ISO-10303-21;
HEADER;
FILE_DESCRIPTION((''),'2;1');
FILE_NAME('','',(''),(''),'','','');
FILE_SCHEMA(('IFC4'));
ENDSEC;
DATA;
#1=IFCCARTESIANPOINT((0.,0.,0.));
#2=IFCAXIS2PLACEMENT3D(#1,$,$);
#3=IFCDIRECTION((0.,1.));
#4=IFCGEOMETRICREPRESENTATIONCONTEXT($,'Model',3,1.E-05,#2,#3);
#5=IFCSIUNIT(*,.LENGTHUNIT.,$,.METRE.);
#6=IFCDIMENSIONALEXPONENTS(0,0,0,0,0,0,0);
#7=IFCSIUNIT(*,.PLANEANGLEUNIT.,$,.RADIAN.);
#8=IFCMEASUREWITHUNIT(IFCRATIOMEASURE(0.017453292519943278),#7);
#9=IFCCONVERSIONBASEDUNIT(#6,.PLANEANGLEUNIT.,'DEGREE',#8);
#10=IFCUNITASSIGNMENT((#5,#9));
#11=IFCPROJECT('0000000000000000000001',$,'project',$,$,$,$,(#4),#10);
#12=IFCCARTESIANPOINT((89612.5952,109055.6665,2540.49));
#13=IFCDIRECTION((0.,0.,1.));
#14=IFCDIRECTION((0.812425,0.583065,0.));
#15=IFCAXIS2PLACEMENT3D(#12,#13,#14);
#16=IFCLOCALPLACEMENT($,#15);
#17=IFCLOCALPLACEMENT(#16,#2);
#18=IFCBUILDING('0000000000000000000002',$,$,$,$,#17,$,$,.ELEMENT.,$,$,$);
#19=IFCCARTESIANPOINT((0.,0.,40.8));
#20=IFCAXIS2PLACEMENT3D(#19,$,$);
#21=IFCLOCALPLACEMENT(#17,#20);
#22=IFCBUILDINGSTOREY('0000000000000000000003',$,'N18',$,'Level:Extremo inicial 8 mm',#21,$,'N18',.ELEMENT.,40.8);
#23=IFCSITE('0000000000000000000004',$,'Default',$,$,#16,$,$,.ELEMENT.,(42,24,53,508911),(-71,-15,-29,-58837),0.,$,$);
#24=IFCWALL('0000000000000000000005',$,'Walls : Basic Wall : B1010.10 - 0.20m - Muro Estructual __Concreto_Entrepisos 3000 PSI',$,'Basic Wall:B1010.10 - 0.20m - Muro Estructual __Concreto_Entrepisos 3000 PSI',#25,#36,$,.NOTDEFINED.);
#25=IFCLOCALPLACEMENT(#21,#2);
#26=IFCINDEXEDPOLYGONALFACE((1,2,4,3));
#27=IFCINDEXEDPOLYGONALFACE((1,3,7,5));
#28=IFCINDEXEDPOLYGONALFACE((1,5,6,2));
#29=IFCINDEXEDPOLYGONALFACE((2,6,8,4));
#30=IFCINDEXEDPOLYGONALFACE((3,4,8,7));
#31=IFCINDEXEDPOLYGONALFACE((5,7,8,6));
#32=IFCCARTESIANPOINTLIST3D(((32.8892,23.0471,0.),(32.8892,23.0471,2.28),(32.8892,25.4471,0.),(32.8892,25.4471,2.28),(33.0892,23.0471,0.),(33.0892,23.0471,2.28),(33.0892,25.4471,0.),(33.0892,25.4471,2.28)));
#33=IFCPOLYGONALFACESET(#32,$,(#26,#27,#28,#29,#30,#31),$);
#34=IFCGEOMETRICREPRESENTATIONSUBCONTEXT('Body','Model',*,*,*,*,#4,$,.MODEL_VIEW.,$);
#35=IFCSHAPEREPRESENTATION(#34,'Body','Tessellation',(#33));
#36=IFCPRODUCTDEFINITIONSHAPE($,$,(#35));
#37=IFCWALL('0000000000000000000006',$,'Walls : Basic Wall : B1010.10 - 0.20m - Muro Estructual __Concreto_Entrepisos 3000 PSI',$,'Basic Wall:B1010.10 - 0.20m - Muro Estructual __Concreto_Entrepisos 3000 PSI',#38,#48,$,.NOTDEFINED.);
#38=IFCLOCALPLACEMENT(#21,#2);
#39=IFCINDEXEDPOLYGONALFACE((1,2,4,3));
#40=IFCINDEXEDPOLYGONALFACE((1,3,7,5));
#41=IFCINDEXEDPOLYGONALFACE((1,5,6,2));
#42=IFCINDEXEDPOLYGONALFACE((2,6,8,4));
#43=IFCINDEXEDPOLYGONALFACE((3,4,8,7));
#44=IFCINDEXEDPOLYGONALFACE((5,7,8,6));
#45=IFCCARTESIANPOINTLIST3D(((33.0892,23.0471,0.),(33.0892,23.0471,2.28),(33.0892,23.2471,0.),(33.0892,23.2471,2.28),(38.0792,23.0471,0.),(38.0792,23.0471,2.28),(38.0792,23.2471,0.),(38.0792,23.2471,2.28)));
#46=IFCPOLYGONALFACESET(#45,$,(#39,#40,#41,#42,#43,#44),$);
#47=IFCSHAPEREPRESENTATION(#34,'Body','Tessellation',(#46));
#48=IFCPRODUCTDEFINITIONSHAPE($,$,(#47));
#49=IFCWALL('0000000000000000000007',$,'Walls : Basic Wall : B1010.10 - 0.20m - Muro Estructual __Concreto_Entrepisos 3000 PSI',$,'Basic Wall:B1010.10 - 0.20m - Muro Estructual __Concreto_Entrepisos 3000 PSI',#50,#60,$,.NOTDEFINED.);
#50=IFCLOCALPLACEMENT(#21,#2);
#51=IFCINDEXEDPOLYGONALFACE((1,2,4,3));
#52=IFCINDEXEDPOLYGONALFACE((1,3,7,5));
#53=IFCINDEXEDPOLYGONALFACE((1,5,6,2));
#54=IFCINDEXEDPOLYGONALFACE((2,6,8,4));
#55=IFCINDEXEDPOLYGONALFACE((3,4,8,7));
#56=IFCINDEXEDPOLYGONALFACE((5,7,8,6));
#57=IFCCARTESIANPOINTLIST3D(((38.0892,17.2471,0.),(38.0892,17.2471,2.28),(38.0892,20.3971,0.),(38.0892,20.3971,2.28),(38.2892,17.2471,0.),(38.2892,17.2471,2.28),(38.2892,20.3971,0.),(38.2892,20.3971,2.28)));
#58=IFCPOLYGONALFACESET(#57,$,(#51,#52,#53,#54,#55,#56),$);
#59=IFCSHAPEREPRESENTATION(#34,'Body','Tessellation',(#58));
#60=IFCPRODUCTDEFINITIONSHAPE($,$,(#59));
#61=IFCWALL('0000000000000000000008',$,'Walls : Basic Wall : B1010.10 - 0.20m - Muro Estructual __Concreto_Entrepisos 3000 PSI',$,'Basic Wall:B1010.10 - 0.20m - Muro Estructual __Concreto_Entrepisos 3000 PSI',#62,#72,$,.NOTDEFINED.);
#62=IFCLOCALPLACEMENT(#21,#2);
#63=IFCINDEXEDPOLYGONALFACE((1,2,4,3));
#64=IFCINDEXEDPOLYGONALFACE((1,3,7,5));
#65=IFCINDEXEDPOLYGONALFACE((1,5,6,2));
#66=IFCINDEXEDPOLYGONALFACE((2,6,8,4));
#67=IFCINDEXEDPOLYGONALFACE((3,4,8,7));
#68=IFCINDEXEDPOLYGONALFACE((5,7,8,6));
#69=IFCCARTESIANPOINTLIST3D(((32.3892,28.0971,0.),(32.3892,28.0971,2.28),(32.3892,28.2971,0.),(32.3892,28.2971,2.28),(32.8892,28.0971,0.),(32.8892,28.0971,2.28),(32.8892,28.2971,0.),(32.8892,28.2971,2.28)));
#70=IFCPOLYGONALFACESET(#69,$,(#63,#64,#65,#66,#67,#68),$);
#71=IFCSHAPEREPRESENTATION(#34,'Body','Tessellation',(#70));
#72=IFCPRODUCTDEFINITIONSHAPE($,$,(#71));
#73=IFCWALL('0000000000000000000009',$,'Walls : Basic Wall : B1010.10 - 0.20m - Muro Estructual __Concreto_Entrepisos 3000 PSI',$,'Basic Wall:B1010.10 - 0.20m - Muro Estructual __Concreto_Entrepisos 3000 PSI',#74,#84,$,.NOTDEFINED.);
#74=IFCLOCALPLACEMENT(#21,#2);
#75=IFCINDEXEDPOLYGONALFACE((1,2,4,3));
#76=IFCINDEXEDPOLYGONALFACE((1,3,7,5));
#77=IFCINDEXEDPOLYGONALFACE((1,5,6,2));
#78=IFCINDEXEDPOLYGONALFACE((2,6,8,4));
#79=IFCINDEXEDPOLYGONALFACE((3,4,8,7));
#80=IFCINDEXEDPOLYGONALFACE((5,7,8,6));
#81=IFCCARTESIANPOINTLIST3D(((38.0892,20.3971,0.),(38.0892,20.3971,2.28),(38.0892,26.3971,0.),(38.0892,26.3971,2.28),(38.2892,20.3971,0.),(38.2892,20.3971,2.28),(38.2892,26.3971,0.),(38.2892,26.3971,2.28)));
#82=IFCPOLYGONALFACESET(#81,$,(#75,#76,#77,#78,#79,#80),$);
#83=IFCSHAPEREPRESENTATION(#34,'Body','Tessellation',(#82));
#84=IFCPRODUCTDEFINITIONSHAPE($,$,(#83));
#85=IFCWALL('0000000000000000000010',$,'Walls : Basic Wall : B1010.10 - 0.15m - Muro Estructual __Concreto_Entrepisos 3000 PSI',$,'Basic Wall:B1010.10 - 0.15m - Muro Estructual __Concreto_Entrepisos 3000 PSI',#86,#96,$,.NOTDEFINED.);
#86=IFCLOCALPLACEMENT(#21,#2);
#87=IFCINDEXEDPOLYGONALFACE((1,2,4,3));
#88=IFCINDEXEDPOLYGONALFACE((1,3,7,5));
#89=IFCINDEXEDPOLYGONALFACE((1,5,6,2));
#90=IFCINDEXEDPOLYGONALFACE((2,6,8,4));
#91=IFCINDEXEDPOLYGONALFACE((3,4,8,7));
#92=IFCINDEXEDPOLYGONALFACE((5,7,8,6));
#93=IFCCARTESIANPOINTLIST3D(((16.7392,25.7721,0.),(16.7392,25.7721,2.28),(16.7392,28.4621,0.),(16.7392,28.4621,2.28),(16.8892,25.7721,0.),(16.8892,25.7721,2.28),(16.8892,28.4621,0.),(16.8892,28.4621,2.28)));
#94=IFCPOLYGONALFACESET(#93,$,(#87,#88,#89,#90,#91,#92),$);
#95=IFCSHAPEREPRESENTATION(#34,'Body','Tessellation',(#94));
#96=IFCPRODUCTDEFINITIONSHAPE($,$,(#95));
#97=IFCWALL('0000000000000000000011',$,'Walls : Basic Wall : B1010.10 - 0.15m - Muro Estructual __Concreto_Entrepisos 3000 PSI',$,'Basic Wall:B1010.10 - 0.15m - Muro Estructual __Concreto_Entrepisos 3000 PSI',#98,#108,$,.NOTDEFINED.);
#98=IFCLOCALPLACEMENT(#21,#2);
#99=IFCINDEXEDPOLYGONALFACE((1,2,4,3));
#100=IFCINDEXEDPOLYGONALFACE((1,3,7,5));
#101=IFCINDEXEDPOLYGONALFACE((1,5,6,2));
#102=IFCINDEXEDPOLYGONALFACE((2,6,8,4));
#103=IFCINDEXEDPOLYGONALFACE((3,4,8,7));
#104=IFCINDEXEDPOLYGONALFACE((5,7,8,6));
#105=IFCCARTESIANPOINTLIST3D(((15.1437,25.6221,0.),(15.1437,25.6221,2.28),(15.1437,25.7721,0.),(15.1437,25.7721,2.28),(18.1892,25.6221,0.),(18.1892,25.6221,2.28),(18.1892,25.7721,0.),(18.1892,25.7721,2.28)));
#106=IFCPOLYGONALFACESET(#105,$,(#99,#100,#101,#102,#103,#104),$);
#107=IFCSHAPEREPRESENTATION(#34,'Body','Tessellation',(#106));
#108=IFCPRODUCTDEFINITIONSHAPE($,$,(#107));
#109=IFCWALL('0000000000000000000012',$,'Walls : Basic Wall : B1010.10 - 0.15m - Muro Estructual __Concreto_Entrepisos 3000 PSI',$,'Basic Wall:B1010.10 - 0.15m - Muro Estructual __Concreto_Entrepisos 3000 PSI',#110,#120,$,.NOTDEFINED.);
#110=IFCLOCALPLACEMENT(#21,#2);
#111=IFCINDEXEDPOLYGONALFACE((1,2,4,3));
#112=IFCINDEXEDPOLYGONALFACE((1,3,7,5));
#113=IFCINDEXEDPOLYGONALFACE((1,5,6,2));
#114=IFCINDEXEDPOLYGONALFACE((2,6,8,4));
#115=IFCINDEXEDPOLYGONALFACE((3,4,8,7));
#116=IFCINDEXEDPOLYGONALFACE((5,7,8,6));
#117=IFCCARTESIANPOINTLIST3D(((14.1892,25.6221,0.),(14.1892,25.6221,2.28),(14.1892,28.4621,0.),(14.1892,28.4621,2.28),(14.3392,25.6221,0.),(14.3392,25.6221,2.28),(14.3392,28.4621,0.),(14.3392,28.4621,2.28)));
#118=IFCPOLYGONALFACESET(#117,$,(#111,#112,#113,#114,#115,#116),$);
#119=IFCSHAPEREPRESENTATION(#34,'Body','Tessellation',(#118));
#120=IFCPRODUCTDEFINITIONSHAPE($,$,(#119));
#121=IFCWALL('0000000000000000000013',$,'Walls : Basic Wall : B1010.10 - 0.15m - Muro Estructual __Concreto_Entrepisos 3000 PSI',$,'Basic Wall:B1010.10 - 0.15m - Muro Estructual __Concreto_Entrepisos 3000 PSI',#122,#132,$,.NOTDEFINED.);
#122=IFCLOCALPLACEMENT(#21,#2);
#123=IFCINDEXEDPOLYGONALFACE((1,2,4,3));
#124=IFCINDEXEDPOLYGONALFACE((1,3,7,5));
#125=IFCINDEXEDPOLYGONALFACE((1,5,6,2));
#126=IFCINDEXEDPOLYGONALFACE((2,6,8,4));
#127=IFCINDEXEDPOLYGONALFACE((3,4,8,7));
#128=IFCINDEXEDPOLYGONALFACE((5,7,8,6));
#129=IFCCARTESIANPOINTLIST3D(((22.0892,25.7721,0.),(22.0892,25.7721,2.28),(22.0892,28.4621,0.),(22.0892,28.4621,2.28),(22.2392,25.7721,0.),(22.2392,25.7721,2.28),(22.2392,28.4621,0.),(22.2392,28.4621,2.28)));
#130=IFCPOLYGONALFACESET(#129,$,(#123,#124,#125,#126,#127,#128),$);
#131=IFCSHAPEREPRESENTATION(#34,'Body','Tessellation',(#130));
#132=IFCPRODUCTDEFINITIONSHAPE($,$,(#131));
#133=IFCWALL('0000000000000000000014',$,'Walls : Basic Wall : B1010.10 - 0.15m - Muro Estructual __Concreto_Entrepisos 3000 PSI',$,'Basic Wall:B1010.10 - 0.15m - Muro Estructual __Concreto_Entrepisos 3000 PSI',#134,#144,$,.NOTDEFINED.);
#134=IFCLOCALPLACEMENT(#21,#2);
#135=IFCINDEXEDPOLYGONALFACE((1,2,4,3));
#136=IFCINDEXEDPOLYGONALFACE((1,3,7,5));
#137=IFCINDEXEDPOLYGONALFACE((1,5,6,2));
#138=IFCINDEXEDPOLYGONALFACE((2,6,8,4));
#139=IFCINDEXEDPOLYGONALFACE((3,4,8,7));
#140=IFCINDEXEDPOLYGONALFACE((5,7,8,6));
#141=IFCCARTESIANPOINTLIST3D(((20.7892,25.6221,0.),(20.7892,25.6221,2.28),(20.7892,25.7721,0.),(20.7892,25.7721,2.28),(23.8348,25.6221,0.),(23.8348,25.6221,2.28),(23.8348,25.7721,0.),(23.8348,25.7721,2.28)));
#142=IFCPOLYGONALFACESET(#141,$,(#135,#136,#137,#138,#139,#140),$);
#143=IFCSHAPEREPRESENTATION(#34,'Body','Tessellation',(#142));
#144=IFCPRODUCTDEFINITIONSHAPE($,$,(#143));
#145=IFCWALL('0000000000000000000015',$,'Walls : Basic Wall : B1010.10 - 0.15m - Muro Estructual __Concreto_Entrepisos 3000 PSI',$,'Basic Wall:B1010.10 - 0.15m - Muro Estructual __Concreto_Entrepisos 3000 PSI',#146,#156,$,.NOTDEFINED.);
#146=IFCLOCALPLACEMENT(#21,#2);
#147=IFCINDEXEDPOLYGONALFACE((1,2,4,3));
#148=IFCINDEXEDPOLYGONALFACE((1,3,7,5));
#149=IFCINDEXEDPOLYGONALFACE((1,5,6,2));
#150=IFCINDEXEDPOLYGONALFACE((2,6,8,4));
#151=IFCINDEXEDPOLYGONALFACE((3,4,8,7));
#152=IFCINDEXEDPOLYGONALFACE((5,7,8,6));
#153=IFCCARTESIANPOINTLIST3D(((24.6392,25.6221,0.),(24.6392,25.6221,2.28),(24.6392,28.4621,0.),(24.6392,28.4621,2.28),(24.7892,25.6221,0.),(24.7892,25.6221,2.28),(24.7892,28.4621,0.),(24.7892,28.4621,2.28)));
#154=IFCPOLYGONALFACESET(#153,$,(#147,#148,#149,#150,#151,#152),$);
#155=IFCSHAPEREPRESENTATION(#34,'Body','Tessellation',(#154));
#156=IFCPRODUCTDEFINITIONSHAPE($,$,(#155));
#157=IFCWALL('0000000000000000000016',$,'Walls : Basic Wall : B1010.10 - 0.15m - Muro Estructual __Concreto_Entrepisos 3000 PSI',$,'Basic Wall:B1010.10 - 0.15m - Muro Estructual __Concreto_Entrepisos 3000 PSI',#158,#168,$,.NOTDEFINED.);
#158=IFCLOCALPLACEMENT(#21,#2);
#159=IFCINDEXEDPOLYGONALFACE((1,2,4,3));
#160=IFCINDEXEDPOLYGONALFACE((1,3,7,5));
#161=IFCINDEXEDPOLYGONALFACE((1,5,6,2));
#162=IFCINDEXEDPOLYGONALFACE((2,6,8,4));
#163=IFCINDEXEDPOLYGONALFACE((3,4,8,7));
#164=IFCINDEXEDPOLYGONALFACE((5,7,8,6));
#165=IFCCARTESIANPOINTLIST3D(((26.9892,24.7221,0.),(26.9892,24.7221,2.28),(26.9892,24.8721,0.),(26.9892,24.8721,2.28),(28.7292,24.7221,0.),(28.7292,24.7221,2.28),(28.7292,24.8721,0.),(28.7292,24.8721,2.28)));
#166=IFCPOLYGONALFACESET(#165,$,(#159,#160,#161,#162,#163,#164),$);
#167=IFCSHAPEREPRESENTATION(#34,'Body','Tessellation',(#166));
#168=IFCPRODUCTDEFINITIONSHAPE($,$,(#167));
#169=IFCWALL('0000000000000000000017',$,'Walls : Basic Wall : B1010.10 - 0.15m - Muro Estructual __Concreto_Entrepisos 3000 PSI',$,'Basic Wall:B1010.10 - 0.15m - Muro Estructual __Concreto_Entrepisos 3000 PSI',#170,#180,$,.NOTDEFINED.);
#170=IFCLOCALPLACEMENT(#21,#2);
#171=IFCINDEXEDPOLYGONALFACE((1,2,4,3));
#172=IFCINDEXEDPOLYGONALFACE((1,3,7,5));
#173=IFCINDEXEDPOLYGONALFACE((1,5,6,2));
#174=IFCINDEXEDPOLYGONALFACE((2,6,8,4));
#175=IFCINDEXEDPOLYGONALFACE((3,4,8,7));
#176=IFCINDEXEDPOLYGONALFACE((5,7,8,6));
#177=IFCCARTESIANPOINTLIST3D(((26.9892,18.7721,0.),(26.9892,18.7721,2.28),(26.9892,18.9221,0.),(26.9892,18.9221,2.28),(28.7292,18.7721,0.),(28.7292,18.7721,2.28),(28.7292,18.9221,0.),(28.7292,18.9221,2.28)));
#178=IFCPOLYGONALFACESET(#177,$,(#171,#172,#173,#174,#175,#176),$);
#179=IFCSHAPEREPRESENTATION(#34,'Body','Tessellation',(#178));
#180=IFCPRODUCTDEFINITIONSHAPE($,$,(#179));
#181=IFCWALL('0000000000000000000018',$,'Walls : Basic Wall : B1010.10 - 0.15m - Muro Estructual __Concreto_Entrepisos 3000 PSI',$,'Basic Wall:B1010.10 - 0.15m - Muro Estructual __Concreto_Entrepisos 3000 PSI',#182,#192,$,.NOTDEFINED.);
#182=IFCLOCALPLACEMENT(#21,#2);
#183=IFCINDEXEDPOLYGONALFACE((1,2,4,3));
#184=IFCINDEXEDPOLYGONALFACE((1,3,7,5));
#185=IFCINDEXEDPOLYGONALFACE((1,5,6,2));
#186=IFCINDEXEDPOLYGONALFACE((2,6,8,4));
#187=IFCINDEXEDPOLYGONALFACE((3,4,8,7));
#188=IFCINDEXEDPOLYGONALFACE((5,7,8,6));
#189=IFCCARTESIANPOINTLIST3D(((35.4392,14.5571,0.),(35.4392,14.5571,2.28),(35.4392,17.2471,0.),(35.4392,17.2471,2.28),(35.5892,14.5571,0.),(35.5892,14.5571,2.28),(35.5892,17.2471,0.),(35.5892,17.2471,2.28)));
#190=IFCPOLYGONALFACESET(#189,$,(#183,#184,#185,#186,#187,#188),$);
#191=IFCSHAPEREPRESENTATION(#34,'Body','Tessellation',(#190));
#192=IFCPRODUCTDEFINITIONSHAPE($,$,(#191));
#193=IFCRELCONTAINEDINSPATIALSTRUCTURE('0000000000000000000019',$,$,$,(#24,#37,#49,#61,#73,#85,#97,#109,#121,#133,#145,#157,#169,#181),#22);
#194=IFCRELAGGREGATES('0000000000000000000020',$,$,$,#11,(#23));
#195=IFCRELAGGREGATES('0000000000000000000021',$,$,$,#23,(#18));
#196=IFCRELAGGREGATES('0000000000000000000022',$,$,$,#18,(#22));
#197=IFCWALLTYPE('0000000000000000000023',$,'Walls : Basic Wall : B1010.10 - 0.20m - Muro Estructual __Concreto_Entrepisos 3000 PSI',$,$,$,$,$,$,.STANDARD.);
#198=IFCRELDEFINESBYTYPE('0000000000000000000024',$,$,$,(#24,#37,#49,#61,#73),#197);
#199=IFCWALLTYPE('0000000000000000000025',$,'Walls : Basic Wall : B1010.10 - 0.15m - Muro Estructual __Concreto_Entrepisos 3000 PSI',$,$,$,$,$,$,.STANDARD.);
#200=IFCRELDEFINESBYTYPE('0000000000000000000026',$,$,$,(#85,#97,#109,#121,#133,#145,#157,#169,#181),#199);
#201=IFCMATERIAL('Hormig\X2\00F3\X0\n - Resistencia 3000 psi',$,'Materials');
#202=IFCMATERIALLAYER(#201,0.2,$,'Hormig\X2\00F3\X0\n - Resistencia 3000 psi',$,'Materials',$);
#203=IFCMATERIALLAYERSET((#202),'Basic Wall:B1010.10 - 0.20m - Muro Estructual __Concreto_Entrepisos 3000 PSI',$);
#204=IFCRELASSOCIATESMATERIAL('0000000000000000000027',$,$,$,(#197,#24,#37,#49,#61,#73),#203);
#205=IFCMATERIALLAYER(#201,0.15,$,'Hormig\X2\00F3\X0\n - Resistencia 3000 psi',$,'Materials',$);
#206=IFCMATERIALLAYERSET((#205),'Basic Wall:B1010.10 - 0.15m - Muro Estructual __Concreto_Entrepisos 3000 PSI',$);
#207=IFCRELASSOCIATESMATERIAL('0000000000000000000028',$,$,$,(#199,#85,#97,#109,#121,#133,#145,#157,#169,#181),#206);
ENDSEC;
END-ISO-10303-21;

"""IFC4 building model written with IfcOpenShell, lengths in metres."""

from ifc_helpers import new_model, entity, si_unit, converted_unit, direction, frame, frame_2d, origin, place, context, subcontext, project, spatial, rectangle, extrude, material, layer, layer_set, layer_usage, type_object, element, save


model = new_model("IFC4")

# Units and contexts
model_context = context("Model", 3, precision=1e-05, world=origin(), true_north=direction((0.0, 1.0)))
body_context = subcontext(model_context, "Body", "Model", "MODEL_VIEW")
ifc_project = project(units=[si_unit("LENGTHUNIT", "METRE"), converted_unit("PLANEANGLEUNIT", "DEGREE", entity("IfcRatioMeasure", 0.017453292519943278), si_unit("PLANEANGLEUNIT", "RADIAN"), dimensions=[0, 0, 0, 0, 0, 0, 0])], contexts=[model_context])

# Site, building, storey
site_placement = place(None, frame((89612.5952, 109055.6665, 2540.49), z_axis=(0.0, 0.0, 1.0), x_axis=(0.812425, 0.583065, 0.0)))
site = spatial("IfcSite", under=ifc_project, at=site_placement, Name="Default", CompositionType="ELEMENT", RefLatitude=(42, 24, 53, 508911), RefLongitude=(-71, -15, -29, -58837), RefElevation=0.0)
building_placement = place(site_placement, origin())
building = spatial("IfcBuilding", under=site, at=building_placement, CompositionType="ELEMENT")
storey_placement = place(building_placement, frame((0.0, 0.0, 40.8)))
storey = spatial("IfcBuildingStorey", under=building, at=storey_placement, Name="N18", ObjectType="Level:Extremo inicial 8 mm", LongName="N18", CompositionType="ELEMENT", Elevation=40.8)

# Walls
ifc_material = material(Name="Hormigón - Resistencia 3000 psi", Category="Materials")
ifc_layer_1 = layer(ifc_material, 0.2, Name="Hormigón - Resistencia 3000 psi", Category="Materials")
ifc_layer_set_1 = layer_set([ifc_layer_1], Name="Basic Wall:B1010.10 - 0.20m - Muro Estructual __Concreto_Entrepisos 3000 PSI")
wall_type_1 = type_object("IfcWallType", Name="Walls : Basic Wall : B1010.10 - 0.20m - Muro Estructual __Concreto_Entrepisos 3000 PSI", PredefinedType="STANDARD", material=ifc_layer_set_1)
ifc_layer_usage_1 = layer_usage(ifc_layer_set_1, "AXIS2", "POSITIVE", -0.1)
wall_1_placement = place(storey_placement, frame((32.9892, 25.4471, 0.0), z_axis=(0.0, 0.0, 1.0), x_axis=(0.0, -1.0, 0.0)))
element("IfcWall", 1, at=wall_1_placement, inside=storey, type_object=wall_type_1, material=ifc_layer_usage_1, Name="Walls : Basic Wall : B1010.10 - 0.20m - Muro Estructual __Concreto_Entrepisos 3000 PSI", ObjectType="Basic Wall:B1010.10 - 0.20m - Muro Estructual __Concreto_Entrepisos 3000 PSI", PredefinedType="NOTDEFINED", context=body_context, shape_type="SweptSolid", body=[
    extrude(rectangle(XDim=2.4, YDim=0.2, at=frame_2d((1.2, 0.0), x_axis=(-1.0, 0.0))), origin(), (0.0, 0.0, 1.0), 2.28),
])
ifc_layer_usage_2 = layer_usage(ifc_layer_set_1, "AXIS2", "POSITIVE", -0.1)
wall_2_placement = place(storey_placement, frame((33.0892, 23.1471, 0.0)))
element("IfcWall", 2, at=wall_2_placement, inside=storey, type_object=wall_type_1, material=ifc_layer_usage_2, Name="Walls : Basic Wall : B1010.10 - 0.20m - Muro Estructual __Concreto_Entrepisos 3000 PSI", ObjectType="Basic Wall:B1010.10 - 0.20m - Muro Estructual __Concreto_Entrepisos 3000 PSI", PredefinedType="NOTDEFINED", context=body_context, shape_type="SweptSolid", body=[
    extrude(rectangle(XDim=4.99, YDim=0.2, at=frame_2d((2.495, 0.0), x_axis=(-1.0, 0.0))), origin(), (0.0, 0.0, 1.0), 2.28),
])
ifc_layer_usage_3 = layer_usage(ifc_layer_set_1, "AXIS2", "POSITIVE", -0.1)
wall_3_placement = place(storey_placement, frame((38.1892, 17.2471, 0.0), z_axis=(0.0, 0.0, 1.0), x_axis=(0.0, 1.0, 0.0)))
element("IfcWall", 3, at=wall_3_placement, inside=storey, type_object=wall_type_1, material=ifc_layer_usage_3, Name="Walls : Basic Wall : B1010.10 - 0.20m - Muro Estructual __Concreto_Entrepisos 3000 PSI", ObjectType="Basic Wall:B1010.10 - 0.20m - Muro Estructual __Concreto_Entrepisos 3000 PSI", PredefinedType="NOTDEFINED", context=body_context, shape_type="SweptSolid", body=[
    extrude(rectangle(XDim=3.15, YDim=0.2, at=frame_2d((1.575, 0.0), x_axis=(-1.0, 0.0))), origin(), (0.0, 0.0, 1.0), 2.28),
])
ifc_layer_usage_4 = layer_usage(ifc_layer_set_1, "AXIS2", "POSITIVE", -0.1)
wall_4_placement = place(storey_placement, frame((32.3892, 28.1971, 0.0)))
element("IfcWall", 4, at=wall_4_placement, inside=storey, type_object=wall_type_1, material=ifc_layer_usage_4, Name="Walls : Basic Wall : B1010.10 - 0.20m - Muro Estructual __Concreto_Entrepisos 3000 PSI", ObjectType="Basic Wall:B1010.10 - 0.20m - Muro Estructual __Concreto_Entrepisos 3000 PSI", PredefinedType="NOTDEFINED", context=body_context, shape_type="SweptSolid", body=[
    extrude(rectangle(XDim=0.5, YDim=0.2, at=frame_2d((0.25, 0.0), x_axis=(-1.0, 0.0))), origin(), (0.0, 0.0, 1.0), 2.28),
])
ifc_layer_usage_5 = layer_usage(ifc_layer_set_1, "AXIS2", "POSITIVE", -0.1)
wall_5_placement = place(storey_placement, frame((38.1892, 20.3971, 0.0), z_axis=(0.0, 0.0, 1.0), x_axis=(0.0, 1.0, 0.0)))
element("IfcWall", 5, at=wall_5_placement, inside=storey, type_object=wall_type_1, material=ifc_layer_usage_5, Name="Walls : Basic Wall : B1010.10 - 0.20m - Muro Estructual __Concreto_Entrepisos 3000 PSI", ObjectType="Basic Wall:B1010.10 - 0.20m - Muro Estructual __Concreto_Entrepisos 3000 PSI", PredefinedType="NOTDEFINED", context=body_context, shape_type="SweptSolid", body=[
    extrude(rectangle(XDim=6.0, YDim=0.2, at=frame_2d((3.0, 0.0), x_axis=(-1.0, 0.0))), origin(), (0.0, 0.0, 1.0), 2.28),
])
ifc_layer_2 = layer(ifc_material, 0.15, Name="Hormigón - Resistencia 3000 psi", Category="Materials")
ifc_layer_set_2 = layer_set([ifc_layer_2], Name="Basic Wall:B1010.10 - 0.15m - Muro Estructual __Concreto_Entrepisos 3000 PSI")
ifc_layer_usage_6 = layer_usage(ifc_layer_set_2, "AXIS2", "POSITIVE", -0.075)
wall_type_2 = type_object("IfcWallType", Name="Walls : Basic Wall : B1010.10 - 0.15m - Muro Estructual __Concreto_Entrepisos 3000 PSI", PredefinedType="STANDARD", material=ifc_layer_set_2)
wall_6_placement = place(storey_placement, frame((16.8142, 28.4621, 0.0), z_axis=(0.0, 0.0, 1.0), x_axis=(0.0, -1.0, 0.0)))
element("IfcWall", 6, at=wall_6_placement, inside=storey, type_object=wall_type_2, material=ifc_layer_usage_6, Name="Walls : Basic Wall : B1010.10 - 0.15m - Muro Estructual __Concreto_Entrepisos 3000 PSI", ObjectType="Basic Wall:B1010.10 - 0.15m - Muro Estructual __Concreto_Entrepisos 3000 PSI", PredefinedType="NOTDEFINED", context=body_context, shape_type="SweptSolid", body=[
    extrude(rectangle(XDim=2.69, YDim=0.15, at=frame_2d((1.345, 0.0), x_axis=(-1.0, 0.0))), origin(), (0.0, 0.0, 1.0), 2.28),
])
ifc_layer_usage_7 = layer_usage(ifc_layer_set_2, "AXIS2", "POSITIVE", -0.075)
wall_7_placement = place(storey_placement, frame((18.1892, 25.6971, 0.0), z_axis=(0.0, 0.0, 1.0), x_axis=(-1.0, 0.0, 0.0)))
element("IfcWall", 7, at=wall_7_placement, inside=storey, type_object=wall_type_2, material=ifc_layer_usage_7, Name="Walls : Basic Wall : B1010.10 - 0.15m - Muro Estructual __Concreto_Entrepisos 3000 PSI", ObjectType="Basic Wall:B1010.10 - 0.15m - Muro Estructual __Concreto_Entrepisos 3000 PSI", PredefinedType="NOTDEFINED", context=body_context, shape_type="SweptSolid", body=[
    extrude(rectangle(XDim=3.0455, YDim=0.15, at=frame_2d((1.5228, 0.0), x_axis=(-1.0, 0.0))), origin(), (0.0, 0.0, 1.0), 2.28),
])
ifc_layer_usage_8 = layer_usage(ifc_layer_set_2, "AXIS2", "POSITIVE", -0.075)
wall_8_placement = place(storey_placement, frame((14.2642, 28.4621, 0.0), z_axis=(0.0, 0.0, 1.0), x_axis=(0.0, -1.0, 0.0)))
element("IfcWall", 8, at=wall_8_placement, inside=storey, type_object=wall_type_2, material=ifc_layer_usage_8, Name="Walls : Basic Wall : B1010.10 - 0.15m - Muro Estructual __Concreto_Entrepisos 3000 PSI", ObjectType="Basic Wall:B1010.10 - 0.15m - Muro Estructual __Concreto_Entrepisos 3000 PSI", PredefinedType="NOTDEFINED", context=body_context, shape_type="SweptSolid", body=[
    extrude(rectangle(XDim=2.84, YDim=0.15, at=frame_2d((1.42, 0.0), x_axis=(-1.0, 0.0))), origin(), (0.0, 0.0, 1.0), 2.28),
])
ifc_layer_usage_9 = layer_usage(ifc_layer_set_2, "AXIS2", "NEGATIVE", 0.075)
wall_9_placement = place(storey_placement, frame((22.1642, 28.4621, 0.0), z_axis=(0.0, 0.0, 1.0), x_axis=(0.0, -1.0, 0.0)))
element("IfcWall", 9, at=wall_9_placement, inside=storey, type_object=wall_type_2, material=ifc_layer_usage_9, Name="Walls : Basic Wall : B1010.10 - 0.15m - Muro Estructual __Concreto_Entrepisos 3000 PSI", ObjectType="Basic Wall:B1010.10 - 0.15m - Muro Estructual __Concreto_Entrepisos 3000 PSI", PredefinedType="NOTDEFINED", context=body_context, shape_type="SweptSolid", body=[
    extrude(rectangle(XDim=2.69, YDim=0.15, at=frame_2d((1.345, 0.0), x_axis=(-1.0, 0.0))), origin(), (0.0, 0.0, 1.0), 2.28),
])
ifc_layer_usage_10 = layer_usage(ifc_layer_set_2, "AXIS2", "NEGATIVE", 0.075)
wall_10_placement = place(storey_placement, frame((20.7892, 25.6971, 0.0)))
element("IfcWall", 10, at=wall_10_placement, inside=storey, type_object=wall_type_2, material=ifc_layer_usage_10, Name="Walls : Basic Wall : B1010.10 - 0.15m - Muro Estructual __Concreto_Entrepisos 3000 PSI", ObjectType="Basic Wall:B1010.10 - 0.15m - Muro Estructual __Concreto_Entrepisos 3000 PSI", PredefinedType="NOTDEFINED", context=body_context, shape_type="SweptSolid", body=[
    extrude(rectangle(XDim=3.0455, YDim=0.15, at=frame_2d((1.5228, 0.0), x_axis=(-1.0, 0.0))), origin(), (0.0, 0.0, 1.0), 2.28),
])
ifc_layer_usage_11 = layer_usage(ifc_layer_set_2, "AXIS2", "NEGATIVE", 0.075)
wall_11_placement = place(storey_placement, frame((24.7142, 28.4621, 0.0), z_axis=(0.0, 0.0, 1.0), x_axis=(0.0, -1.0, 0.0)))
element("IfcWall", 11, at=wall_11_placement, inside=storey, type_object=wall_type_2, material=ifc_layer_usage_11, Name="Walls : Basic Wall : B1010.10 - 0.15m - Muro Estructual __Concreto_Entrepisos 3000 PSI", ObjectType="Basic Wall:B1010.10 - 0.15m - Muro Estructual __Concreto_Entrepisos 3000 PSI", PredefinedType="NOTDEFINED", context=body_context, shape_type="SweptSolid", body=[
    extrude(rectangle(XDim=2.84, YDim=0.15, at=frame_2d((1.42, 0.0), x_axis=(-1.0, 0.0))), origin(), (0.0, 0.0, 1.0), 2.28),
])
ifc_layer_usage_12 = layer_usage(ifc_layer_set_2, "AXIS2", "NEGATIVE", 0.075)
wall_12_placement = place(storey_placement, frame((26.9892, 24.7971, 0.0)))
element("IfcWall", 12, at=wall_12_placement, inside=storey, type_object=wall_type_2, material=ifc_layer_usage_12, Name="Walls : Basic Wall : B1010.10 - 0.15m - Muro Estructual __Concreto_Entrepisos 3000 PSI", ObjectType="Basic Wall:B1010.10 - 0.15m - Muro Estructual __Concreto_Entrepisos 3000 PSI", PredefinedType="NOTDEFINED", context=body_context, shape_type="SweptSolid", body=[
    extrude(rectangle(XDim=1.74, YDim=0.15, at=frame_2d((0.87, 0.0), x_axis=(-1.0, 0.0))), origin(), (0.0, 0.0, 1.0), 2.28),
])
ifc_layer_usage_13 = layer_usage(ifc_layer_set_2, "AXIS2", "POSITIVE", -0.075)
wall_13_placement = place(storey_placement, frame((26.9892, 18.8471, 0.0)))
element("IfcWall", 13, at=wall_13_placement, inside=storey, type_object=wall_type_2, material=ifc_layer_usage_13, Name="Walls : Basic Wall : B1010.10 - 0.15m - Muro Estructual __Concreto_Entrepisos 3000 PSI", ObjectType="Basic Wall:B1010.10 - 0.15m - Muro Estructual __Concreto_Entrepisos 3000 PSI", PredefinedType="NOTDEFINED", context=body_context, shape_type="SweptSolid", body=[
    extrude(rectangle(XDim=1.74, YDim=0.15, at=frame_2d((0.87, 0.0), x_axis=(-1.0, 0.0))), origin(), (0.0, 0.0, 1.0), 2.28),
])
ifc_layer_usage_14 = layer_usage(ifc_layer_set_2, "AXIS2", "NEGATIVE", 0.075)
wall_14_placement = place(storey_placement, frame((35.5142, 14.5571, 0.0), z_axis=(0.0, 0.0, 1.0), x_axis=(0.0, 1.0, 0.0)))
element("IfcWall", 14, at=wall_14_placement, inside=storey, type_object=wall_type_2, material=ifc_layer_usage_14, Name="Walls : Basic Wall : B1010.10 - 0.15m - Muro Estructual __Concreto_Entrepisos 3000 PSI", ObjectType="Basic Wall:B1010.10 - 0.15m - Muro Estructual __Concreto_Entrepisos 3000 PSI", PredefinedType="NOTDEFINED", context=body_context, shape_type="SweptSolid", body=[
    extrude(rectangle(XDim=2.69, YDim=0.15, at=frame_2d((1.345, 0.0), x_axis=(-1.0, 0.0))), origin(), (0.0, 0.0, 1.0), 2.28),
])

save(model, "model.ifc")
